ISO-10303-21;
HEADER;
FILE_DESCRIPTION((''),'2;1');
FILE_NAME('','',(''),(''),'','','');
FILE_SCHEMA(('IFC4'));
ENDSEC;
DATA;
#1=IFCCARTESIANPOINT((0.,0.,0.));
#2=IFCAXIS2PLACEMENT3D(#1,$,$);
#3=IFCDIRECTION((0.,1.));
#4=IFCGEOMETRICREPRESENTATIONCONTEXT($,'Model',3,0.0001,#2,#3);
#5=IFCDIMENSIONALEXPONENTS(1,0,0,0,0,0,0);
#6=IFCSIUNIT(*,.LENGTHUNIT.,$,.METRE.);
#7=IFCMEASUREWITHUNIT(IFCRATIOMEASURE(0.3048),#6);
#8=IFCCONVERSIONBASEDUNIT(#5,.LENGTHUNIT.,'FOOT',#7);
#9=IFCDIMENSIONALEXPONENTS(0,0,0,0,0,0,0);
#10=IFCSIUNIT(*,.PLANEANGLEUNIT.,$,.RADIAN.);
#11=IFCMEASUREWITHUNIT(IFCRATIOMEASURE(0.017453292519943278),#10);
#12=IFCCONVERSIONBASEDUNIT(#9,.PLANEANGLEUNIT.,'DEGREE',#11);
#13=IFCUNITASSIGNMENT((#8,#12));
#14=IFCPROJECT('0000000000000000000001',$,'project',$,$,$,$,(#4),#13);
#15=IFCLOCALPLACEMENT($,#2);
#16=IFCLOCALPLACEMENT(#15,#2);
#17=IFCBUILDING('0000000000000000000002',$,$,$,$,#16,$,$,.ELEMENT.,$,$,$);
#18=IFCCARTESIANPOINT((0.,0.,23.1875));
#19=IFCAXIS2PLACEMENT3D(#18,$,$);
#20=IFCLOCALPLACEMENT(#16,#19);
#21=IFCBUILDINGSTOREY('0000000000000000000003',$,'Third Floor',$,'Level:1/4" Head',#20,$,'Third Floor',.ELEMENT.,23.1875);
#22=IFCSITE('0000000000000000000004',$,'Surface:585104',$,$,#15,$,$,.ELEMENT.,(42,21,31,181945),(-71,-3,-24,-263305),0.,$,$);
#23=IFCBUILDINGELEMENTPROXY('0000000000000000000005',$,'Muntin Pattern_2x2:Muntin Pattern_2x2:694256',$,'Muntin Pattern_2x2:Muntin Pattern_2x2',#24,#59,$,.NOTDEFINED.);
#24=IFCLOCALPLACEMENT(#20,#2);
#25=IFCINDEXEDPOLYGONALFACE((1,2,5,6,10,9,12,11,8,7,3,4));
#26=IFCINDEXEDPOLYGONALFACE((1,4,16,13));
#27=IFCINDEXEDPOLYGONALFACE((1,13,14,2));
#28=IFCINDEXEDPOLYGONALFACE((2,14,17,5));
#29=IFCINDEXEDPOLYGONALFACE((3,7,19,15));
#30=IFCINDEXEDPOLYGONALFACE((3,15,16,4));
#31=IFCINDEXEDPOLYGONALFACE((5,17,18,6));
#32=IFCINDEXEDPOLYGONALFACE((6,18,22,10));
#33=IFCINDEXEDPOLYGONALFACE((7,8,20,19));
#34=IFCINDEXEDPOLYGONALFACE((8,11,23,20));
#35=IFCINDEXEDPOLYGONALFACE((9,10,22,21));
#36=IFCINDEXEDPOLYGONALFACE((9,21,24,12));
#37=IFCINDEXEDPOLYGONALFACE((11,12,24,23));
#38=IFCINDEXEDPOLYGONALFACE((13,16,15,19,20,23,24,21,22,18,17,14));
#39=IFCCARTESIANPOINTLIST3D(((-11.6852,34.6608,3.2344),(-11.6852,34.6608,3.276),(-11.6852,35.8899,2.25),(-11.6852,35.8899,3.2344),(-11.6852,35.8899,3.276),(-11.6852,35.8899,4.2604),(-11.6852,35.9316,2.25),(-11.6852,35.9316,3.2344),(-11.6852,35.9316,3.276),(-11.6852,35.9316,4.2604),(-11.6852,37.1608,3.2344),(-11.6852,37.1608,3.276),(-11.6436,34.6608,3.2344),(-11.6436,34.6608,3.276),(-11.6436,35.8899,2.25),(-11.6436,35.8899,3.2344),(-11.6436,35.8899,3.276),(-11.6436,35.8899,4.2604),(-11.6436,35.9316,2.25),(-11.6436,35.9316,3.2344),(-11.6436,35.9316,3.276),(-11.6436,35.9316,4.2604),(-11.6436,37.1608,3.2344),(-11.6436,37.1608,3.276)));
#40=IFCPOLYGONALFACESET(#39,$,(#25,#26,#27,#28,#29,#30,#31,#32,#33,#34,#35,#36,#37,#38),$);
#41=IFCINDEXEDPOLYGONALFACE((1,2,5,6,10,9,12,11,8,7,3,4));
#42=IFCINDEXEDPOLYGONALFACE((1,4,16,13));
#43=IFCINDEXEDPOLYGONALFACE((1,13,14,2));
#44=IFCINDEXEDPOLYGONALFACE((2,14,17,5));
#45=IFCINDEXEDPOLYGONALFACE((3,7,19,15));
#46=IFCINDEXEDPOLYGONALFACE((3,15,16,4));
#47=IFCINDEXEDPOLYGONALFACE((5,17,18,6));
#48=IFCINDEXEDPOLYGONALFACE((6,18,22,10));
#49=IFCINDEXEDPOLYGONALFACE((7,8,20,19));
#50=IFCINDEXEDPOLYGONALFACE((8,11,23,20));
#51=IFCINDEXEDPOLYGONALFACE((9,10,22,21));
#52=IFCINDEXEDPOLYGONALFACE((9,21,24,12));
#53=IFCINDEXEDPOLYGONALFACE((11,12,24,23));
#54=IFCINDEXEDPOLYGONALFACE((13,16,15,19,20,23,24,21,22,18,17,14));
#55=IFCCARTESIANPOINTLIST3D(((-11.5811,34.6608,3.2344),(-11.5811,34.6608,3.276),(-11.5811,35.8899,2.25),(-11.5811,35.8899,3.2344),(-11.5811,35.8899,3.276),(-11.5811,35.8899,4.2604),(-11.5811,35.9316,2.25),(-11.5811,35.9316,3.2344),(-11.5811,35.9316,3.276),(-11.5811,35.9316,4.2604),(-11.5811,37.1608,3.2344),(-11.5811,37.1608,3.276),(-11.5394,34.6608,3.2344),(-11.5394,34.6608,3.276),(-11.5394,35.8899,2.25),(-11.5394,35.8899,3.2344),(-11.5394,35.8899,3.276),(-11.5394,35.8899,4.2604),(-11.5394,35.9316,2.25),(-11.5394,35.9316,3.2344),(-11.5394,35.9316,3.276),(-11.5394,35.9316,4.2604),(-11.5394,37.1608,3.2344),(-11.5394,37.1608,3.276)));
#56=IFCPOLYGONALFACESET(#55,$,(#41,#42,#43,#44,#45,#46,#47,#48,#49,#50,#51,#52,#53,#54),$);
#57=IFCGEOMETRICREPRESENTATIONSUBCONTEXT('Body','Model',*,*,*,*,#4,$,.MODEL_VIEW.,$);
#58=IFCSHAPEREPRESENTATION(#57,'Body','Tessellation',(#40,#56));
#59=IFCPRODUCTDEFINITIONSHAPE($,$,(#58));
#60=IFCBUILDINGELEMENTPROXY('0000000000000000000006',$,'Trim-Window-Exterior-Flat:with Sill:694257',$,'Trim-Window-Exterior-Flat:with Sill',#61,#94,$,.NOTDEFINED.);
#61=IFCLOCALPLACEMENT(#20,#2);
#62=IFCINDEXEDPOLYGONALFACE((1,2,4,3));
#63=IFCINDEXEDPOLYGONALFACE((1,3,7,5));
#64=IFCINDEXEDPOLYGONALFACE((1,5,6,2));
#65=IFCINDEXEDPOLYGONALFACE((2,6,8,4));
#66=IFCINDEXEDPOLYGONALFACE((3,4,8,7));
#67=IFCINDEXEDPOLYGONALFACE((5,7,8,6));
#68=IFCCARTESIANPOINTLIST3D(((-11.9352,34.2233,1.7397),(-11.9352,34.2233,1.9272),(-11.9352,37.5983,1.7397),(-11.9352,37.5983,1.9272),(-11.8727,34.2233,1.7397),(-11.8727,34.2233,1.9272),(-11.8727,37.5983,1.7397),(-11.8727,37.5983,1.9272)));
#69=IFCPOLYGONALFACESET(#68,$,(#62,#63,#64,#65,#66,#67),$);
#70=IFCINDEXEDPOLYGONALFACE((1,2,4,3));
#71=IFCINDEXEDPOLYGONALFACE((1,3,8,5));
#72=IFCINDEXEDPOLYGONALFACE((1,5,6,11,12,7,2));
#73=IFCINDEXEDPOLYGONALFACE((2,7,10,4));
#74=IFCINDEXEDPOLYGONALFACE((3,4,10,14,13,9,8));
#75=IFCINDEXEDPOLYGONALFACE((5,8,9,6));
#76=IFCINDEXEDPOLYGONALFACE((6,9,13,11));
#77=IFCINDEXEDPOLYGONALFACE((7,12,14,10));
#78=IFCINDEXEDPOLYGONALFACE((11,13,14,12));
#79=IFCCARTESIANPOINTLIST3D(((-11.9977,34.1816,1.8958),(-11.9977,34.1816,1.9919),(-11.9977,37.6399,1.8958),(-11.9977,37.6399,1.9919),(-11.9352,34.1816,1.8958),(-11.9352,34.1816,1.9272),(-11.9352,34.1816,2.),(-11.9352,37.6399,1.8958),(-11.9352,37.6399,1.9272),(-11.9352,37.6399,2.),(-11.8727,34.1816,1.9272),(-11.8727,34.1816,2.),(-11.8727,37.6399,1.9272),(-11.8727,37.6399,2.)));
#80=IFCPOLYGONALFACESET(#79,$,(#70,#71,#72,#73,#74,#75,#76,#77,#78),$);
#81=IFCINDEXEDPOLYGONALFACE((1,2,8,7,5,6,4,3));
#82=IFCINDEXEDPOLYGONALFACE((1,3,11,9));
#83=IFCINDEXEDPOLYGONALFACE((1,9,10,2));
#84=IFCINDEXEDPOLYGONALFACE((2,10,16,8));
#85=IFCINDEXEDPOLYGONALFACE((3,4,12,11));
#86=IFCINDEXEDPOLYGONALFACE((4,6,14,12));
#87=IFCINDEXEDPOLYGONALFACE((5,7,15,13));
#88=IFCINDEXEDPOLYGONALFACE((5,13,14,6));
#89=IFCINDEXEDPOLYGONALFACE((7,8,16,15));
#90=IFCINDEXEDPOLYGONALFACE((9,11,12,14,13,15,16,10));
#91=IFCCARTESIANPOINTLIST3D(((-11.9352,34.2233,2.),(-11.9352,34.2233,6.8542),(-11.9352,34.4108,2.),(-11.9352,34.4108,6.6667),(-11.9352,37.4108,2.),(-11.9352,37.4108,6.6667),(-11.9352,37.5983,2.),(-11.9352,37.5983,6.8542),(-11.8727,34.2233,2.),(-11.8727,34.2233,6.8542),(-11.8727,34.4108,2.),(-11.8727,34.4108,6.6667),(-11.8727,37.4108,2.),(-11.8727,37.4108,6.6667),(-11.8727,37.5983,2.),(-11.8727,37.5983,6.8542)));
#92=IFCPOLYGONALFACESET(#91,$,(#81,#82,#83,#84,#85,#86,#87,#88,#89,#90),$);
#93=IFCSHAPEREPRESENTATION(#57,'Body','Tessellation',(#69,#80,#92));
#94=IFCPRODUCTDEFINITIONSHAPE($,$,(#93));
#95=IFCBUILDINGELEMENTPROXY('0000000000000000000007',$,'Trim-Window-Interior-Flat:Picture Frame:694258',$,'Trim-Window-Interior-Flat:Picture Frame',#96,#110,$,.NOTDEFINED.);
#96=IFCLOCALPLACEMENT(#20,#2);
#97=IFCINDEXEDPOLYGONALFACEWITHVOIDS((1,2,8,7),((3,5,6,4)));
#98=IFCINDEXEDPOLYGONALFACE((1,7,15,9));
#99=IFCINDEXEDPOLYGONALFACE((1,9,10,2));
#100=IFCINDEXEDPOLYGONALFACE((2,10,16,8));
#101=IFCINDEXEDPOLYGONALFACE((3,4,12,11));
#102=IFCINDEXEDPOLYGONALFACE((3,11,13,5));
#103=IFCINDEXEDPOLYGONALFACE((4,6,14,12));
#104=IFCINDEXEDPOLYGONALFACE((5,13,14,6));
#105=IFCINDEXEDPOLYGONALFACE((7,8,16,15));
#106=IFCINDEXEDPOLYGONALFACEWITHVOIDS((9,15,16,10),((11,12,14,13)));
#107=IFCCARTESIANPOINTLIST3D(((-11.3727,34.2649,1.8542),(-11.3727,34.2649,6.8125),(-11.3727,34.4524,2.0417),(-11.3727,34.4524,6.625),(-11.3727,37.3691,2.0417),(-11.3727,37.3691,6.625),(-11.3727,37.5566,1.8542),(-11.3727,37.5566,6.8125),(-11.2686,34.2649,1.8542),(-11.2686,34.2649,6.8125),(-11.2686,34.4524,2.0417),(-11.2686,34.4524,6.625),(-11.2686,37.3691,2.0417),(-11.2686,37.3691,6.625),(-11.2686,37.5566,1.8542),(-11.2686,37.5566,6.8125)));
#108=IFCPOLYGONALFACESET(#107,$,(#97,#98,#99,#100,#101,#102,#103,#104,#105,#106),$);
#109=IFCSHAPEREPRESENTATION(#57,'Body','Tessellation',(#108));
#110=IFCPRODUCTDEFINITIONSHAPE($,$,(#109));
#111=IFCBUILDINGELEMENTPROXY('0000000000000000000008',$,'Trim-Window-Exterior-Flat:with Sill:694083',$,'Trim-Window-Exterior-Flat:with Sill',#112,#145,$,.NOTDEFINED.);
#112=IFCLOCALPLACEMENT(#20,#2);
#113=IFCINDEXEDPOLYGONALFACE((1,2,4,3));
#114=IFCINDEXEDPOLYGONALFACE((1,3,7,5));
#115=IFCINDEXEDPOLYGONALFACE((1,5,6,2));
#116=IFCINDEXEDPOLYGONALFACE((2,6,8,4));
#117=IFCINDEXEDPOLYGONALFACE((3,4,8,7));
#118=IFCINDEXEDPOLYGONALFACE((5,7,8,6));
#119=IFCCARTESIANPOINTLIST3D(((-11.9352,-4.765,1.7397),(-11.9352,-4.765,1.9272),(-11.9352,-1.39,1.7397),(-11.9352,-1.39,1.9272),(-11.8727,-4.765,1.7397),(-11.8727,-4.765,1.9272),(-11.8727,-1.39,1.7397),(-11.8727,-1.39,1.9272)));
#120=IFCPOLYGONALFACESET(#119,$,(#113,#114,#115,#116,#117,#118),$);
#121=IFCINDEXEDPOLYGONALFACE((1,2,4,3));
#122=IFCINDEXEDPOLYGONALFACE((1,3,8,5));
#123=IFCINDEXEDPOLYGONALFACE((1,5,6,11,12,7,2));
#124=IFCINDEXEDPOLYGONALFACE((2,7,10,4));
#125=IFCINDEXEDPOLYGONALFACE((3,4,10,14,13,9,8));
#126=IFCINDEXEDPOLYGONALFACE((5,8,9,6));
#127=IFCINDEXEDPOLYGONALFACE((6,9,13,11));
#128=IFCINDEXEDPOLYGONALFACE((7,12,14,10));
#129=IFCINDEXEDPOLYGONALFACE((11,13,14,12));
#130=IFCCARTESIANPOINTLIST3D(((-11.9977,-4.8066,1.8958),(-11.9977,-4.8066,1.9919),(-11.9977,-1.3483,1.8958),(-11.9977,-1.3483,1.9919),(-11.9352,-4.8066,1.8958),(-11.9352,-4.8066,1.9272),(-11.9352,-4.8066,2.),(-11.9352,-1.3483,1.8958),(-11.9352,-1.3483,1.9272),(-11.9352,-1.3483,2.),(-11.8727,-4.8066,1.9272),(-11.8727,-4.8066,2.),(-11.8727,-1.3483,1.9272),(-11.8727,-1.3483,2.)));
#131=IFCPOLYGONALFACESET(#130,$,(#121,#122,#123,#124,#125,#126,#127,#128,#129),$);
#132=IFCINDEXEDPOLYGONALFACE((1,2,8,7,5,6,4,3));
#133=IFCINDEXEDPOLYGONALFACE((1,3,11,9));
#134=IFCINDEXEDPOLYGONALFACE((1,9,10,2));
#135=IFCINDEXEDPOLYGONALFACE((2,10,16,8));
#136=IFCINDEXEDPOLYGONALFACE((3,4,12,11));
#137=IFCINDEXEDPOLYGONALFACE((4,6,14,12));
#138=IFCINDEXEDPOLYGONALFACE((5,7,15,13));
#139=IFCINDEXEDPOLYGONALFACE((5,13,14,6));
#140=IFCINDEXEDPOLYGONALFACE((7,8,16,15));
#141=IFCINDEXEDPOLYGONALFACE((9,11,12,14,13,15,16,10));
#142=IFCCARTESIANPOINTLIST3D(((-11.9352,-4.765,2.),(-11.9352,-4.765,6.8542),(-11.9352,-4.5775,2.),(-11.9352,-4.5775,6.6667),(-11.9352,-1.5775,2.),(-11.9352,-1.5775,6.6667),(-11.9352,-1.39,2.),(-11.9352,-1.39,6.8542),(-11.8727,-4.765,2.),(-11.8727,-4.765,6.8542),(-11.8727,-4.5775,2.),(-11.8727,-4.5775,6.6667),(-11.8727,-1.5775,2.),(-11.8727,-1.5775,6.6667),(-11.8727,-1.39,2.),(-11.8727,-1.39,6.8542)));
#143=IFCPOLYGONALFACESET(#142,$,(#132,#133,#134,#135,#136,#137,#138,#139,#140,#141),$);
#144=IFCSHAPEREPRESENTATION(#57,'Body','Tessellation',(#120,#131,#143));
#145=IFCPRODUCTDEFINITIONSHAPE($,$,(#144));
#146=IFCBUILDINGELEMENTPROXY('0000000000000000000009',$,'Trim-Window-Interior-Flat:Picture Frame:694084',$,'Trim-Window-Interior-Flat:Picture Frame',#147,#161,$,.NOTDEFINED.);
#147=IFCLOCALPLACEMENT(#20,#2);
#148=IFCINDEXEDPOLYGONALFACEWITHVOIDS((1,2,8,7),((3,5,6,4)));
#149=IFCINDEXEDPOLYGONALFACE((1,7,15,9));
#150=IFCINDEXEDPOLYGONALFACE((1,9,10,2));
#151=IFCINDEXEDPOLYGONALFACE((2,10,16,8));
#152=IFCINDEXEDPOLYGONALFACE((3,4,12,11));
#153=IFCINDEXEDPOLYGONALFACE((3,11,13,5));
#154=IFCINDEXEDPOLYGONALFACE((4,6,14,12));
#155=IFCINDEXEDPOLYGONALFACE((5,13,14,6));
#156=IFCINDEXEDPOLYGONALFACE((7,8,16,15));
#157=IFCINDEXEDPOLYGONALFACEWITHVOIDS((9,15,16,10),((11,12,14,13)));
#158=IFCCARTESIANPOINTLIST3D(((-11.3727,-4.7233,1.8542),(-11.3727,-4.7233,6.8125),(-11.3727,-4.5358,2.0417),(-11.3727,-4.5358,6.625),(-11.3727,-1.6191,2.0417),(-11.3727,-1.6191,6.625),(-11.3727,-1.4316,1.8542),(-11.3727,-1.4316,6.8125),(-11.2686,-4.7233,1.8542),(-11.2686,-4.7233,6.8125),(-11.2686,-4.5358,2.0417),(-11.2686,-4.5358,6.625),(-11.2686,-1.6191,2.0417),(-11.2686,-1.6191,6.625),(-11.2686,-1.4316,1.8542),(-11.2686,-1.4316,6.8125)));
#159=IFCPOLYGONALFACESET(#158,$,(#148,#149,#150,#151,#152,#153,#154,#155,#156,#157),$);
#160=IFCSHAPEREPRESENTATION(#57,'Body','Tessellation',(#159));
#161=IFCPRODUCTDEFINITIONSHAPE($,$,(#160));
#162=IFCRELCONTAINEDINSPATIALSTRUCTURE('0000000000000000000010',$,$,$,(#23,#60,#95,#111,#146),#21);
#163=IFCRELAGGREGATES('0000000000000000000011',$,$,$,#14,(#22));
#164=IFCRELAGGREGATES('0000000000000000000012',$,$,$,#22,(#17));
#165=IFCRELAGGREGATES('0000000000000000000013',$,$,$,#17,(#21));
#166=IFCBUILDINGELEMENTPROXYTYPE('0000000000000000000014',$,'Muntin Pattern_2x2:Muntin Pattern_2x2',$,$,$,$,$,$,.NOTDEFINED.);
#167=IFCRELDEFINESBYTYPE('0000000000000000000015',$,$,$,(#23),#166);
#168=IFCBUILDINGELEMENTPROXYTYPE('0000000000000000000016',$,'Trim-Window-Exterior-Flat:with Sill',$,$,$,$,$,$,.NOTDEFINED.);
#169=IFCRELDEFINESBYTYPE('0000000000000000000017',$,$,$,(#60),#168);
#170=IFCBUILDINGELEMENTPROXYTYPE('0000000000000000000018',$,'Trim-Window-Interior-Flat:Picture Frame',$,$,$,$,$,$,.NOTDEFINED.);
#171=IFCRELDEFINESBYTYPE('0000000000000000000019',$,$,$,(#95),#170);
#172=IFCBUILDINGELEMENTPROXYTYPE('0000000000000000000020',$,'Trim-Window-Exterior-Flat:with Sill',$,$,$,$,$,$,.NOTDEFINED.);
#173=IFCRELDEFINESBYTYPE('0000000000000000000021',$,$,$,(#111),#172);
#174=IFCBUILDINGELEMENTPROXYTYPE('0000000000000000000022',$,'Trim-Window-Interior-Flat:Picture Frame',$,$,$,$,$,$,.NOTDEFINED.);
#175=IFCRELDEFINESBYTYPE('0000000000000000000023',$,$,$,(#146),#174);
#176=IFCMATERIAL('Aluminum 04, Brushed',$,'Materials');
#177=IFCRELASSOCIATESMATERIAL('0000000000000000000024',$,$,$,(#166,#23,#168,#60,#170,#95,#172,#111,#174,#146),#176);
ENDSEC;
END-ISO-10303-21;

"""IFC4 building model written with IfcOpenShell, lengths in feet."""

from ifc_helpers import new_model, entity, si_unit, converted_unit, direction, frame, origin, place, context, subcontext, project, spatial, indexed_curve, outline, extrude, source, transform, mapped, material, type_object, type_shapes, element, save


model = new_model("IFC4")

# Units and contexts
model_context = context("Model", 3, precision=0.0001, world=origin(), true_north=direction((0.0, 1.0)))
body_context = subcontext(model_context, "Body", "Model", "MODEL_VIEW")
ifc_project = project(units=[converted_unit("LENGTHUNIT", "FOOT", entity("IfcRatioMeasure", 0.3048), si_unit("LENGTHUNIT", "METRE"), dimensions=[1, 0, 0, 0, 0, 0, 0]), converted_unit("PLANEANGLEUNIT", "DEGREE", entity("IfcRatioMeasure", 0.017453292519943278), si_unit("PLANEANGLEUNIT", "RADIAN"), dimensions=[0, 0, 0, 0, 0, 0, 0])], contexts=[model_context])

# Site, building, storey
site_placement = place(None, origin())
site = spatial("IfcSite", under=ifc_project, at=site_placement, Name="Surface:585104", CompositionType="ELEMENT", RefLatitude=(42, 21, 31, 181945), RefLongitude=(-71, -3, -24, -263305), RefElevation=0.0)
building_placement = place(site_placement, origin())
building = spatial("IfcBuilding", under=site, at=building_placement, CompositionType="ELEMENT")
storey_placement = place(building_placement, frame((0.0, 0.0, 23.1875)))
storey = spatial("IfcBuildingStorey", under=building, at=storey_placement, Name="Third Floor", ObjectType="Level:1/4\" Head", LongName="Third Floor", CompositionType="ELEMENT", Elevation=23.1875)

# Shared definitions
ifc_material_1 = material(Name="Aluminum 04, Brushed", Category="Materials")

# Building element proxies
building_element_proxy_type_1 = type_object("IfcBuildingElementProxyType", Name="Muntin Pattern_2x2:Muntin Pattern_2x2", PredefinedType="NOTDEFINED", material=ifc_material_1)
shared_shape_1 = source(origin(), body_context, "Body", "SweptSolid", [
    extrude(outline(indexed_curve([(0.0208, -0.0208), (1.0052, -0.0208), (1.0052, 0.0208), (0.0208, 0.0208), (0.0208, 1.25), (-0.0208, 1.25), (-0.0208, 0.0208), (-1.0052, 0.0208), (-1.0052, -0.0208), (-0.0208, -0.0208), (-0.0208, -1.25), (0.0208, -1.25), (0.0208, -0.0208)], self_intersect=False)), frame((0.0, -0.0729, 1.0052), z_axis=(0.0, 1.0, 0.0), x_axis=(0.0, 0.0, 1.0)), (0.0, 0.0, 1.0), 0.0417),
    extrude(outline(indexed_curve([(0.0208, -0.0208), (1.0052, -0.0208), (1.0052, 0.0208), (0.0208, 0.0208), (0.0208, 1.25), (-0.0208, 1.25), (-0.0208, 0.0208), (-1.0052, 0.0208), (-1.0052, -0.0208), (-0.0208, -0.0208), (-0.0208, -1.25), (0.0208, -1.25), (0.0208, -0.0208)], self_intersect=False)), frame((0.0, 0.0313, 1.0052), z_axis=(0.0, 1.0, 0.0), x_axis=(0.0, 0.0, 1.0)), (0.0, 0.0, 1.0), 0.0417),
])
type_shapes(building_element_proxy_type_1, [shared_shape_1])
for number, where, z_axis, x_axis, name in (
    (1, (-11.6123, 35.9108, 2.25), (0.0, 0.0, 1.0), (0.0, -1.0, 0.0), "Muntin Pattern_2x2:Muntin Pattern_2x2:694256"),
):
    element("IfcBuildingElementProxy", number, at=place(storey_placement, frame(where, z_axis=z_axis, x_axis=x_axis)), inside=storey, type_object=building_element_proxy_type_1, material=ifc_material_1, Name=name, ObjectType="Muntin Pattern_2x2:Muntin Pattern_2x2", PredefinedType="NOTDEFINED", context=body_context, shape_type="MappedRepresentation", body=[
        mapped(shared_shape_1, transform((0.0, 0.0, 0.0), scale=1.0)),
    ])
building_element_proxy_type_2 = type_object("IfcBuildingElementProxyType", Name="Trim-Window-Exterior-Flat:with Sill", PredefinedType="NOTDEFINED", material=ifc_material_1)
shared_shape_2 = source(origin(), body_context, "Body", "SweptSolid", [
    extrude(outline(indexed_curve([(-0.0938, -1.6875), (0.0938, -1.6875), (0.0938, 1.6875), (-0.0938, 1.6875), (-0.0938, -1.6875)], self_intersect=False)), frame((0.0, 4.8332, 0.0), z_axis=(0.0, 0.0, 1.0), x_axis=(0.0, 1.0, 0.0)), (0.0, 0.0, 1.0), 0.0625),
    extrude(outline(indexed_curve([(-0.0525, -0.0625), (0.0436, -0.0625), (0.0517, 0.0), (0.0517, 0.0625), (-0.0211, 0.0625), (-0.0211, 0.0), (-0.0525, 0.0), (-0.0525, -0.0625)], self_intersect=False)), frame((-1.7292, 4.7184, 0.0625), z_axis=(1.0, 0.0, 0.0), x_axis=(0.0, -1.0, 0.0)), (0.0, 0.0, 1.0), 3.4583),
    extrude(outline(indexed_curve([(-1.6875, -2.474), (1.6875, -2.474), (1.6875, 2.3802), (1.5, 2.3802), (1.5, -2.2865), (-1.5, -2.2865), (-1.5, 2.3802), (-1.6875, 2.3802), (-1.6875, -2.474)], self_intersect=False)), frame((0.0, 2.2865, 0.0)), (0.0, 0.0, 1.0), 0.0625),
])
type_shapes(building_element_proxy_type_2, [shared_shape_2])
proxy_1_placement = place(storey_placement, frame((-11.8727, 35.9108, 6.6667), z_axis=(-1.0, 0.0, 0.0), x_axis=(0.0, 1.0, 0.0)))
element("IfcBuildingElementProxy", 2, at=proxy_1_placement, inside=storey, type_object=building_element_proxy_type_2, material=ifc_material_1, Name="Trim-Window-Exterior-Flat:with Sill:694257", ObjectType="Trim-Window-Exterior-Flat:with Sill", PredefinedType="NOTDEFINED", context=body_context, shape_type="MappedRepresentation", body=[
    mapped(shared_shape_2, transform((0.0, 0.0, 0.0), scale=1.0)),
])
building_element_proxy_type_3 = type_object("IfcBuildingElementProxyType", Name="Trim-Window-Interior-Flat:Picture Frame", PredefinedType="NOTDEFINED", material=ifc_material_1)
shared_shape_3 = source(origin(), body_context, "Body", "SweptSolid", [
    extrude(outline(indexed_curve([(-2.4792, -1.6458), (2.4792, -1.6458), (2.4792, 1.6458), (-2.4792, 1.6458), (-2.4792, -1.6458)], self_intersect=False), holes=[indexed_curve([(-2.2917, -1.4583), (-2.2917, 1.4583), (2.2917, 1.4583), (2.2917, -1.4583), (-2.2917, -1.4583)], self_intersect=False)]), frame((0.0, 2.3333, 0.0), z_axis=(0.0, 0.0, 1.0), x_axis=(0.0, 1.0, 0.0)), (0.0, 0.0, 1.0), 0.1042),
])
type_shapes(building_element_proxy_type_3, [shared_shape_3])
proxy_2_placement = place(storey_placement, frame((-11.3727, 35.9108, 6.6667), z_axis=(1.0, 0.0, 0.0), x_axis=(0.0, -1.0, 0.0)))
element("IfcBuildingElementProxy", 3, at=proxy_2_placement, inside=storey, type_object=building_element_proxy_type_3, material=ifc_material_1, Name="Trim-Window-Interior-Flat:Picture Frame:694258", ObjectType="Trim-Window-Interior-Flat:Picture Frame", PredefinedType="NOTDEFINED", context=body_context, shape_type="MappedRepresentation", body=[
    mapped(shared_shape_3, transform((0.0, 0.0, 0.0), scale=1.0)),
])
building_element_proxy_type_4 = type_object("IfcBuildingElementProxyType", Name="Trim-Window-Exterior-Flat:with Sill", PredefinedType="NOTDEFINED", material=ifc_material_1)
shared_shape_4 = source(origin(), body_context, "Body", "SweptSolid", [
    extrude(outline(indexed_curve([(-1.6875, -0.0938), (1.6875, -0.0938), (1.6875, 0.0938), (-1.6875, 0.0938), (-1.6875, -0.0938)], self_intersect=False)), frame((0.0, -4.8332, 0.0), z_axis=(0.0, 0.0, 1.0), x_axis=(-1.0, 0.0, 0.0)), (0.0, 0.0, 1.0), 0.0625),
    extrude(outline(indexed_curve([(-0.0625, -0.0525), (0.0, -0.0525), (0.0, -0.0211), (0.0625, -0.0211), (0.0625, 0.0517), (0.0, 0.0517), (-0.0625, 0.0436), (-0.0625, -0.0525)], self_intersect=False)), frame((-1.7292, -4.7184, 0.0625), z_axis=(1.0, 0.0, 0.0), x_axis=(0.0, 0.0, -1.0)), (0.0, 0.0, 1.0), 3.4583),
    extrude(outline(indexed_curve([(-2.474, -1.6875), (2.3802, -1.6875), (2.3802, -1.5), (-2.2865, -1.5), (-2.2865, 1.5), (2.3802, 1.5), (2.3802, 1.6875), (-2.474, 1.6875), (-2.474, -1.6875)], self_intersect=False)), frame((0.0, -2.2865, 0.0), z_axis=(0.0, 0.0, 1.0), x_axis=(0.0, -1.0, 0.0)), (0.0, 0.0, 1.0), 0.0625),
])
type_shapes(building_element_proxy_type_4, [shared_shape_4])
proxy_3_placement = place(storey_placement, frame((-11.8727, -3.0775, 6.6667), z_axis=(-1.0, 0.0, 0.0), x_axis=(0.0, -1.0, 0.0)))
element("IfcBuildingElementProxy", 4, at=proxy_3_placement, inside=storey, type_object=building_element_proxy_type_4, material=ifc_material_1, Name="Trim-Window-Exterior-Flat:with Sill:694083", ObjectType="Trim-Window-Exterior-Flat:with Sill", PredefinedType="NOTDEFINED", context=body_context, shape_type="MappedRepresentation", body=[
    mapped(shared_shape_4, transform((0.0, 0.0, 0.0), scale=1.0)),
])
building_element_proxy_type_5 = type_object("IfcBuildingElementProxyType", Name="Trim-Window-Interior-Flat:Picture Frame", PredefinedType="NOTDEFINED", material=ifc_material_1)
shared_shape_5 = source(origin(), body_context, "Body", "SweptSolid", [
    extrude(outline(indexed_curve([(-1.6458, -2.4792), (1.6458, -2.4792), (1.6458, 2.4792), (-1.6458, 2.4792), (-1.6458, -2.4792)], self_intersect=False), holes=[indexed_curve([(-1.4583, -2.2917), (-1.4583, 2.2917), (1.4583, 2.2917), (1.4583, -2.2917), (-1.4583, -2.2917)], self_intersect=False)]), frame((0.0, -2.3333, 0.0), z_axis=(0.0, 0.0, 1.0), x_axis=(-1.0, 0.0, 0.0)), (0.0, 0.0, 1.0), 0.1042),
])
type_shapes(building_element_proxy_type_5, [shared_shape_5])
proxy_4_placement = place(storey_placement, frame((-11.3727, -3.0775, 6.6667), z_axis=(1.0, 0.0, 0.0), x_axis=(0.0, 1.0, 0.0)))
element("IfcBuildingElementProxy", 5, at=proxy_4_placement, inside=storey, type_object=building_element_proxy_type_5, material=ifc_material_1, Name="Trim-Window-Interior-Flat:Picture Frame:694084", ObjectType="Trim-Window-Interior-Flat:Picture Frame", PredefinedType="NOTDEFINED", context=body_context, shape_type="MappedRepresentation", body=[
    mapped(shared_shape_5, transform((0.0, 0.0, 0.0), scale=1.0)),
])

save(model, "model.ifc")
